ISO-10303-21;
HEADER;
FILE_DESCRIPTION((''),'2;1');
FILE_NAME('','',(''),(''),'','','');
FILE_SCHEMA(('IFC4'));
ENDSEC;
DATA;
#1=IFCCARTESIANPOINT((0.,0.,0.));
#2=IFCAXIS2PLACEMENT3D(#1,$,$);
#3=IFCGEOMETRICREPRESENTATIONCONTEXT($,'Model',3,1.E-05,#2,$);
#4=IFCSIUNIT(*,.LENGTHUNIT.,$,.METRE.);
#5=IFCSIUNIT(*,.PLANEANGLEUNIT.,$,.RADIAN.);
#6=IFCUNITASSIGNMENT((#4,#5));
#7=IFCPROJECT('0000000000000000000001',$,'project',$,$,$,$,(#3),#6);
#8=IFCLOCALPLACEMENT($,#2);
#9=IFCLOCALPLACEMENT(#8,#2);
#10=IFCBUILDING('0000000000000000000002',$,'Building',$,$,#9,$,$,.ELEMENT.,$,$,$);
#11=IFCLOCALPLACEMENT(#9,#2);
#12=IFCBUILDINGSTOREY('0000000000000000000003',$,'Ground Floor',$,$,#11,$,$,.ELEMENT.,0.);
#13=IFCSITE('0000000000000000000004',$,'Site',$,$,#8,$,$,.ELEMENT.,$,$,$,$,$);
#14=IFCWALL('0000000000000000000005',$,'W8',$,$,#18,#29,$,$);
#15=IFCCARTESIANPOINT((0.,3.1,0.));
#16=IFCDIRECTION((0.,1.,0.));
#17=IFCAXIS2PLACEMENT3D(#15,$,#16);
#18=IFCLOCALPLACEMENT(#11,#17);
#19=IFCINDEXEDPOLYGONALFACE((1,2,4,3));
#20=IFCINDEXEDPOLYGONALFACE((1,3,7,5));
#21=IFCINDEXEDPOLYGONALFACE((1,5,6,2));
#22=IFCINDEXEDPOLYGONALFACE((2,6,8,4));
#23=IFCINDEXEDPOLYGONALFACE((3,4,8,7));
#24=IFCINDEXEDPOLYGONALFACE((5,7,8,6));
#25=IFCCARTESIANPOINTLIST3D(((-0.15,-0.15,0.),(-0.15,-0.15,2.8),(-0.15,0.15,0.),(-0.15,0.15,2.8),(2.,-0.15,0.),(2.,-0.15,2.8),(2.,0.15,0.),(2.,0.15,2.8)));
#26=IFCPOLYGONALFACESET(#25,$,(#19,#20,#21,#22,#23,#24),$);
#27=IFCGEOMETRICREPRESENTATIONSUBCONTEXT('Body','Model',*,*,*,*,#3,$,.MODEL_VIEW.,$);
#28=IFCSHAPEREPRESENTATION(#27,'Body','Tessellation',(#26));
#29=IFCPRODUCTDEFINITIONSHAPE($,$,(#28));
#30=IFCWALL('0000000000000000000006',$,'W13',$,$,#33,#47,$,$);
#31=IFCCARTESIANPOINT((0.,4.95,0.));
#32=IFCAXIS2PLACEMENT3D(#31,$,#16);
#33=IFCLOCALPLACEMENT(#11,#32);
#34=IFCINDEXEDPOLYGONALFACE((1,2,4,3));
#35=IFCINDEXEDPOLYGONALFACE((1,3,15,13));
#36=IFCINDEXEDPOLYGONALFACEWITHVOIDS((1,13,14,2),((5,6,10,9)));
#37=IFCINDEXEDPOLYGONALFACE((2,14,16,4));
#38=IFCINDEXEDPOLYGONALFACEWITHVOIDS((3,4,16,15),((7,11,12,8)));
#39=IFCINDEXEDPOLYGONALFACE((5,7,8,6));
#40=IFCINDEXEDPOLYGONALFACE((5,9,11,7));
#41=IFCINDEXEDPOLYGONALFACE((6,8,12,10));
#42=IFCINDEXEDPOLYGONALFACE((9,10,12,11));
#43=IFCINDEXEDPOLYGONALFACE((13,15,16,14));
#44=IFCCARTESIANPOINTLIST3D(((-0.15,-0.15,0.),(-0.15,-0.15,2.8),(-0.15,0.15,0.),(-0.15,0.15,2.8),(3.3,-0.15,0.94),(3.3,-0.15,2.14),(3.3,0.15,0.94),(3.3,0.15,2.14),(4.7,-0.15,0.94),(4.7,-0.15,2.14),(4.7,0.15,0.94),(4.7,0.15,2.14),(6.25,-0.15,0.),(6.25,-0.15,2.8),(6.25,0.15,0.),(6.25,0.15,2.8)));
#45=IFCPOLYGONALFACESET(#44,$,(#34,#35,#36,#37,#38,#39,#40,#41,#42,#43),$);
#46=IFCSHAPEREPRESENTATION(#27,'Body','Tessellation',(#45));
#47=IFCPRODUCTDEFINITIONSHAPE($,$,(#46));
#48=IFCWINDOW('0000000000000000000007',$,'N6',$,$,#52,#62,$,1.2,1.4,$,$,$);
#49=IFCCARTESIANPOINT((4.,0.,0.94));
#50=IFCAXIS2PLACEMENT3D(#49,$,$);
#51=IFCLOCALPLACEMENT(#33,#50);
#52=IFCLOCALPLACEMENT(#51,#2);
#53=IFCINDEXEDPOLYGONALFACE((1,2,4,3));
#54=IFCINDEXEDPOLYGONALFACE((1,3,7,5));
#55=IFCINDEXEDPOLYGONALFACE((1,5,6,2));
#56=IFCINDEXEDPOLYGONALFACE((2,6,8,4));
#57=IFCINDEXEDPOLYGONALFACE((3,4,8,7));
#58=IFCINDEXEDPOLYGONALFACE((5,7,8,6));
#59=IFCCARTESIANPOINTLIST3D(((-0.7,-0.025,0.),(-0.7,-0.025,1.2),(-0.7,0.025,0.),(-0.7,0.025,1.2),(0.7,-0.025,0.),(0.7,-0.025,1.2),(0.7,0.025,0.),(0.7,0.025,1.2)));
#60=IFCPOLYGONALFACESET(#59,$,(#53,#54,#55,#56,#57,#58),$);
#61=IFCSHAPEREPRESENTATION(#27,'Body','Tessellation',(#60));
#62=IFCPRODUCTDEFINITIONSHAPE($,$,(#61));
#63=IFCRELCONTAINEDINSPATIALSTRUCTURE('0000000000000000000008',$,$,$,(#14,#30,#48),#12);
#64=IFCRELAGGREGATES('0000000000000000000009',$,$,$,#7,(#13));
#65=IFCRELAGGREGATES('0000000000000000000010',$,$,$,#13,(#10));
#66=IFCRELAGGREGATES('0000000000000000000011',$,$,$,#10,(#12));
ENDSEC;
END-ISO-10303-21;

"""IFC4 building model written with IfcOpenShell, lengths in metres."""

from ifc_helpers import new_model, si_unit, frame, frame_2d, origin, origin_2d, place, context, subcontext, project, spatial, rectangle, extrude, element, fill, save


model = new_model("IFC4")

# Units and contexts
model_context = context("Model", 3, precision=1e-05, world=origin())
body_context = subcontext(model_context, "Body", "Model", "MODEL_VIEW")
ifc_project = project(units=[si_unit("LENGTHUNIT", "METRE"), si_unit("PLANEANGLEUNIT", "RADIAN")], contexts=[model_context])

# Site, building, storey
site_placement = place(None, origin())
site = spatial("IfcSite", under=ifc_project, at=site_placement, Name="Site", CompositionType="ELEMENT")
building_placement = place(site_placement, origin())
building = spatial("IfcBuilding", under=site, at=building_placement, Name="Building", CompositionType="ELEMENT")
storey_placement = place(building_placement, origin())
storey = spatial("IfcBuildingStorey", under=building, at=storey_placement, Name="Ground Floor", CompositionType="ELEMENT", Elevation=0.0)

# Wall
wall_1_placement = place(storey_placement, frame((0.0, 3.1, 0.0), x_axis=(0.0, 1.0, 0.0)))
element("IfcWall", 1, at=wall_1_placement, inside=storey, Name="W8", context=body_context, shape_type="SweptSolid", body=[
    extrude(rectangle(XDim=2.15, YDim=0.3, at=frame_2d((0.925, 0.0))), origin(), (0.0, 0.0, 1.0), 2.8),
])

# Wall, opening, window
wall_2_placement = place(storey_placement, frame((0.0, 4.95, 0.0), x_axis=(0.0, 1.0, 0.0)))
wall_2 = element("IfcWall", 2, at=wall_2_placement, inside=storey, Name="W13", context=body_context, shape_type="SweptSolid", body=[
    extrude(rectangle(XDim=6.4, YDim=0.3, at=frame_2d((3.05, 0.0))), origin(), (0.0, 0.0, 1.0), 2.8),
])
opening_1_placement = place(wall_2_placement, frame((4.0, 0.0, 0.94)))
opening_1 = element("IfcOpeningElement", 3, at=opening_1_placement, cuts=wall_2, context=body_context, shape_type="SweptSolid", body=[
    extrude(rectangle(XDim=1.4, YDim=0.4, at=origin_2d()), origin(), (0.0, 0.0, 1.0), 1.2),
])
window_1_placement = place(opening_1_placement, origin())
window_1 = element("IfcWindow", 4, at=window_1_placement, inside=storey, Name="N6", OverallHeight=1.2, OverallWidth=1.4, context=body_context, shape_type="SweptSolid", body=[
    extrude(rectangle(XDim=1.4, YDim=0.05, at=origin_2d()), origin(), (0.0, 0.0, 1.0), 1.2),
])
fill(opening_1, window_1)

save(model, "model.ifc")
